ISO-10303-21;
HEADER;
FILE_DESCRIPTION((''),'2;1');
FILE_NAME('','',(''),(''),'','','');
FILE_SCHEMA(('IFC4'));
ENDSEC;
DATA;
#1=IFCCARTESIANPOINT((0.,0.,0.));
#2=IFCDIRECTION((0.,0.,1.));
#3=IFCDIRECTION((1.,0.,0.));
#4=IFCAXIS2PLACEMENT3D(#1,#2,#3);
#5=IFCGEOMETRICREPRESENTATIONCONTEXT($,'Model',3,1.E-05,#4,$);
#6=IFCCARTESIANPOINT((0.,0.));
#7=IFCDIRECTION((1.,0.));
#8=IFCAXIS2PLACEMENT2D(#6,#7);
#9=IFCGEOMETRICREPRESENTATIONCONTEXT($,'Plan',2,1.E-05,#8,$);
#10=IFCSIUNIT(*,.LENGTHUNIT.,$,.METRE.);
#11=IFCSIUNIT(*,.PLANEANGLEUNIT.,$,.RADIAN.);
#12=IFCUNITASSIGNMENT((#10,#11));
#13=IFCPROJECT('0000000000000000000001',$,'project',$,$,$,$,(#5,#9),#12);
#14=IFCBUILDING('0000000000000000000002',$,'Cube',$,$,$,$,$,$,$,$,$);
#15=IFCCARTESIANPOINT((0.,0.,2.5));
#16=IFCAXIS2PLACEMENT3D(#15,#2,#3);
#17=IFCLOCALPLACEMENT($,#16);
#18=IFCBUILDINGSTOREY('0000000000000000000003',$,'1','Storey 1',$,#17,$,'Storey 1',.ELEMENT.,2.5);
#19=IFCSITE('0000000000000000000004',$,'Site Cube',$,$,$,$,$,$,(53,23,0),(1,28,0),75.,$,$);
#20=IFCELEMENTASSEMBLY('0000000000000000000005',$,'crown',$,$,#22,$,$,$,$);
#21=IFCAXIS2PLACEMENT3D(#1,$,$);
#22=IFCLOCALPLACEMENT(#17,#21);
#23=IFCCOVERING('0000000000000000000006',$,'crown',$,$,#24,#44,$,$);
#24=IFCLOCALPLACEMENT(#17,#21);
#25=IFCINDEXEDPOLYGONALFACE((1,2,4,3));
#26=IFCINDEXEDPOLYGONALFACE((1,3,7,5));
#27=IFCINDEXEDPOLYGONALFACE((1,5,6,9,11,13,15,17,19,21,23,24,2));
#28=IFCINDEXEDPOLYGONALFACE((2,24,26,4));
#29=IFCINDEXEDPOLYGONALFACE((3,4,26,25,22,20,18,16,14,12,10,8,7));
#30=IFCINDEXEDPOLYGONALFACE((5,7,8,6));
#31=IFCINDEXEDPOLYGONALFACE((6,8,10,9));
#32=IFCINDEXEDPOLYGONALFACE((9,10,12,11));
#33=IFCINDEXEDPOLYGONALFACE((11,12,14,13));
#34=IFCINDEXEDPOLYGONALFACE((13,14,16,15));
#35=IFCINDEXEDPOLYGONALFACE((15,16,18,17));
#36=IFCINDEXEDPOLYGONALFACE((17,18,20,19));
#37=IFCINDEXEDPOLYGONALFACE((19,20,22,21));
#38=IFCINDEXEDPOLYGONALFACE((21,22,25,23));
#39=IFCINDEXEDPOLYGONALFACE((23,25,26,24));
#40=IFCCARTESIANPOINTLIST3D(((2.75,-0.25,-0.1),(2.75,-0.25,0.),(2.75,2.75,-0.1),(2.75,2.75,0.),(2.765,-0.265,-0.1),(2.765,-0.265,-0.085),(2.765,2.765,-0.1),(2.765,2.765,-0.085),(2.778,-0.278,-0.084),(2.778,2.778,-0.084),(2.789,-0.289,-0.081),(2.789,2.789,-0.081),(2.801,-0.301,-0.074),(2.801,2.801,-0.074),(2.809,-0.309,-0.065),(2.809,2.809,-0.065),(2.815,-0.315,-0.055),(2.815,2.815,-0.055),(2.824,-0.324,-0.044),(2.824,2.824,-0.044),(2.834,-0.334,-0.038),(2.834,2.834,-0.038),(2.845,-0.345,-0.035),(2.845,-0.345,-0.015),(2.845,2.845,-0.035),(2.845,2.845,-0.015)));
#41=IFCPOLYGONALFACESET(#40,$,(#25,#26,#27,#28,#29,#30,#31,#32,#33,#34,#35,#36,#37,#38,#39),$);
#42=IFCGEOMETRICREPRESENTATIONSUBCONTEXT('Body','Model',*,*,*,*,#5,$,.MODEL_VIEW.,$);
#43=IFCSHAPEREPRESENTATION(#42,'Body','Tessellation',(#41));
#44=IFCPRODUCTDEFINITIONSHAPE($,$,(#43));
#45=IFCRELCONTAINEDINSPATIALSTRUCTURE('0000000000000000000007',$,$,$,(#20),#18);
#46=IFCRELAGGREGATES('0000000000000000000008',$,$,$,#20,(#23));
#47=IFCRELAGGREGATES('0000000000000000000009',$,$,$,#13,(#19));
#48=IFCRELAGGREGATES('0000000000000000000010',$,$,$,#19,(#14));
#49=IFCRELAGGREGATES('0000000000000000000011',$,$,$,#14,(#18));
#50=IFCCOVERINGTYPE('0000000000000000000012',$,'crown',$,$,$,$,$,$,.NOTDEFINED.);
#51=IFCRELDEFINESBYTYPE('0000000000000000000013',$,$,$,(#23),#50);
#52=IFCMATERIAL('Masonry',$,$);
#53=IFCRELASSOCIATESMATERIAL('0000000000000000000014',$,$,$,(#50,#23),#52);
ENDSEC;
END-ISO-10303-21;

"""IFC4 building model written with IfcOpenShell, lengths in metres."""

from ifc_helpers import new_model, si_unit, frame, origin_with_axes, origin_2d_with_axis, place, context, subcontext, project, spatial, polyline, outline, extrude, clip, halfspace, material, material_profile, profile_set, profile_usage, type_object, element, aggregate, save


model = new_model("IFC4")

# Units and contexts
model_context = context("Model", 3, precision=1e-05, world=origin_with_axes())
plan_context = context("Plan", 2, precision=1e-05, world=origin_2d_with_axis())
body_context = subcontext(model_context, "Body", "Model", "MODEL_VIEW")
ifc_project = project(units=[si_unit("LENGTHUNIT", "METRE"), si_unit("PLANEANGLEUNIT", "RADIAN")], contexts=[model_context, plan_context])

# Site, building, storey
site = spatial("IfcSite", under=ifc_project, Name="Site Cube", RefLatitude=(53, 23, 0), RefLongitude=(1, 28, 0), RefElevation=75.0)
building = spatial("IfcBuilding", under=site, Name="Cube")
storey_placement = place(None, frame((0.0, 0.0, 2.5), z_axis=(0.0, 0.0, 1.0), x_axis=(1.0, 0.0, 0.0)))
storey = spatial("IfcBuildingStorey", under=building, at=storey_placement, Name="1", Description="Storey 1", LongName="Storey 1", CompositionType="ELEMENT", Elevation=2.5)

# Shared definitions
ifc_material_1 = material(Name="Masonry")

# Element assembly, covering
assembly_1_placement = place(storey_placement, frame((0.0, 0.0, -2.5), z_axis=(0.0, 0.0, 1.0), x_axis=(1.0, 0.0, 0.0)))
assembly_1 = element("IfcElementAssembly", 1, at=assembly_1_placement, inside=storey, Name="crown")
ifc_material_profile_1 = material_profile(ifc_material_1, outline(polyline([(0.25, -0.1), (0.265, -0.1), (0.265, -0.085), (0.278, -0.084), (0.289, -0.081), (0.301, -0.074), (0.309, -0.065), (0.315, -0.055), (0.324, -0.044), (0.334, -0.038), (0.345, -0.035), (0.345, -0.015), (0.25, 0.0), (0.25, -0.1)])))
ifc_profile_set_1 = profile_set([ifc_material_profile_1])
covering_type_1 = type_object("IfcCoveringType", Name="crown", PredefinedType="NOTDEFINED", material=ifc_profile_set_1)
ifc_profile_usage_1 = profile_usage(ifc_profile_set_1)
covering_1_placement = place(assembly_1_placement, frame((2.5, 3.5, 2.5), z_axis=(0.0, -1.0, 0.0), x_axis=(1.0, 0.0, 0.0)))
covering_1 = element("IfcCovering", 2, at=covering_1_placement, type_object=covering_type_1, material=ifc_profile_usage_1, Name="crown", context=body_context, shape_type="Clipping", body=[
    clip(clip(extrude(outline(polyline([(0.25, -0.1), (0.265, -0.1), (0.265, -0.085), (0.278, -0.084), (0.289, -0.081), (0.301, -0.074), (0.309, -0.065), (0.315, -0.055), (0.324, -0.044), (0.334, -0.038), (0.345, -0.035), (0.345, -0.015), (0.25, 0.0), (0.25, -0.1)])), origin_with_axes(), (0.0, 0.0, 1.0), 4.5), halfspace(frame((0.0, -2.5, 1.0), z_axis=(-0.707107, 0.0, -0.707107), x_axis=(0.707107, 0.0, -0.707107)), False)), halfspace(frame((0.0, -2.5, 3.5), z_axis=(-0.707107, 0.0, 0.707107), x_axis=(0.707107, 0.0, 0.707107)), False)),
])
aggregate(assembly_1, [covering_1])

save(model, "model.ifc")
